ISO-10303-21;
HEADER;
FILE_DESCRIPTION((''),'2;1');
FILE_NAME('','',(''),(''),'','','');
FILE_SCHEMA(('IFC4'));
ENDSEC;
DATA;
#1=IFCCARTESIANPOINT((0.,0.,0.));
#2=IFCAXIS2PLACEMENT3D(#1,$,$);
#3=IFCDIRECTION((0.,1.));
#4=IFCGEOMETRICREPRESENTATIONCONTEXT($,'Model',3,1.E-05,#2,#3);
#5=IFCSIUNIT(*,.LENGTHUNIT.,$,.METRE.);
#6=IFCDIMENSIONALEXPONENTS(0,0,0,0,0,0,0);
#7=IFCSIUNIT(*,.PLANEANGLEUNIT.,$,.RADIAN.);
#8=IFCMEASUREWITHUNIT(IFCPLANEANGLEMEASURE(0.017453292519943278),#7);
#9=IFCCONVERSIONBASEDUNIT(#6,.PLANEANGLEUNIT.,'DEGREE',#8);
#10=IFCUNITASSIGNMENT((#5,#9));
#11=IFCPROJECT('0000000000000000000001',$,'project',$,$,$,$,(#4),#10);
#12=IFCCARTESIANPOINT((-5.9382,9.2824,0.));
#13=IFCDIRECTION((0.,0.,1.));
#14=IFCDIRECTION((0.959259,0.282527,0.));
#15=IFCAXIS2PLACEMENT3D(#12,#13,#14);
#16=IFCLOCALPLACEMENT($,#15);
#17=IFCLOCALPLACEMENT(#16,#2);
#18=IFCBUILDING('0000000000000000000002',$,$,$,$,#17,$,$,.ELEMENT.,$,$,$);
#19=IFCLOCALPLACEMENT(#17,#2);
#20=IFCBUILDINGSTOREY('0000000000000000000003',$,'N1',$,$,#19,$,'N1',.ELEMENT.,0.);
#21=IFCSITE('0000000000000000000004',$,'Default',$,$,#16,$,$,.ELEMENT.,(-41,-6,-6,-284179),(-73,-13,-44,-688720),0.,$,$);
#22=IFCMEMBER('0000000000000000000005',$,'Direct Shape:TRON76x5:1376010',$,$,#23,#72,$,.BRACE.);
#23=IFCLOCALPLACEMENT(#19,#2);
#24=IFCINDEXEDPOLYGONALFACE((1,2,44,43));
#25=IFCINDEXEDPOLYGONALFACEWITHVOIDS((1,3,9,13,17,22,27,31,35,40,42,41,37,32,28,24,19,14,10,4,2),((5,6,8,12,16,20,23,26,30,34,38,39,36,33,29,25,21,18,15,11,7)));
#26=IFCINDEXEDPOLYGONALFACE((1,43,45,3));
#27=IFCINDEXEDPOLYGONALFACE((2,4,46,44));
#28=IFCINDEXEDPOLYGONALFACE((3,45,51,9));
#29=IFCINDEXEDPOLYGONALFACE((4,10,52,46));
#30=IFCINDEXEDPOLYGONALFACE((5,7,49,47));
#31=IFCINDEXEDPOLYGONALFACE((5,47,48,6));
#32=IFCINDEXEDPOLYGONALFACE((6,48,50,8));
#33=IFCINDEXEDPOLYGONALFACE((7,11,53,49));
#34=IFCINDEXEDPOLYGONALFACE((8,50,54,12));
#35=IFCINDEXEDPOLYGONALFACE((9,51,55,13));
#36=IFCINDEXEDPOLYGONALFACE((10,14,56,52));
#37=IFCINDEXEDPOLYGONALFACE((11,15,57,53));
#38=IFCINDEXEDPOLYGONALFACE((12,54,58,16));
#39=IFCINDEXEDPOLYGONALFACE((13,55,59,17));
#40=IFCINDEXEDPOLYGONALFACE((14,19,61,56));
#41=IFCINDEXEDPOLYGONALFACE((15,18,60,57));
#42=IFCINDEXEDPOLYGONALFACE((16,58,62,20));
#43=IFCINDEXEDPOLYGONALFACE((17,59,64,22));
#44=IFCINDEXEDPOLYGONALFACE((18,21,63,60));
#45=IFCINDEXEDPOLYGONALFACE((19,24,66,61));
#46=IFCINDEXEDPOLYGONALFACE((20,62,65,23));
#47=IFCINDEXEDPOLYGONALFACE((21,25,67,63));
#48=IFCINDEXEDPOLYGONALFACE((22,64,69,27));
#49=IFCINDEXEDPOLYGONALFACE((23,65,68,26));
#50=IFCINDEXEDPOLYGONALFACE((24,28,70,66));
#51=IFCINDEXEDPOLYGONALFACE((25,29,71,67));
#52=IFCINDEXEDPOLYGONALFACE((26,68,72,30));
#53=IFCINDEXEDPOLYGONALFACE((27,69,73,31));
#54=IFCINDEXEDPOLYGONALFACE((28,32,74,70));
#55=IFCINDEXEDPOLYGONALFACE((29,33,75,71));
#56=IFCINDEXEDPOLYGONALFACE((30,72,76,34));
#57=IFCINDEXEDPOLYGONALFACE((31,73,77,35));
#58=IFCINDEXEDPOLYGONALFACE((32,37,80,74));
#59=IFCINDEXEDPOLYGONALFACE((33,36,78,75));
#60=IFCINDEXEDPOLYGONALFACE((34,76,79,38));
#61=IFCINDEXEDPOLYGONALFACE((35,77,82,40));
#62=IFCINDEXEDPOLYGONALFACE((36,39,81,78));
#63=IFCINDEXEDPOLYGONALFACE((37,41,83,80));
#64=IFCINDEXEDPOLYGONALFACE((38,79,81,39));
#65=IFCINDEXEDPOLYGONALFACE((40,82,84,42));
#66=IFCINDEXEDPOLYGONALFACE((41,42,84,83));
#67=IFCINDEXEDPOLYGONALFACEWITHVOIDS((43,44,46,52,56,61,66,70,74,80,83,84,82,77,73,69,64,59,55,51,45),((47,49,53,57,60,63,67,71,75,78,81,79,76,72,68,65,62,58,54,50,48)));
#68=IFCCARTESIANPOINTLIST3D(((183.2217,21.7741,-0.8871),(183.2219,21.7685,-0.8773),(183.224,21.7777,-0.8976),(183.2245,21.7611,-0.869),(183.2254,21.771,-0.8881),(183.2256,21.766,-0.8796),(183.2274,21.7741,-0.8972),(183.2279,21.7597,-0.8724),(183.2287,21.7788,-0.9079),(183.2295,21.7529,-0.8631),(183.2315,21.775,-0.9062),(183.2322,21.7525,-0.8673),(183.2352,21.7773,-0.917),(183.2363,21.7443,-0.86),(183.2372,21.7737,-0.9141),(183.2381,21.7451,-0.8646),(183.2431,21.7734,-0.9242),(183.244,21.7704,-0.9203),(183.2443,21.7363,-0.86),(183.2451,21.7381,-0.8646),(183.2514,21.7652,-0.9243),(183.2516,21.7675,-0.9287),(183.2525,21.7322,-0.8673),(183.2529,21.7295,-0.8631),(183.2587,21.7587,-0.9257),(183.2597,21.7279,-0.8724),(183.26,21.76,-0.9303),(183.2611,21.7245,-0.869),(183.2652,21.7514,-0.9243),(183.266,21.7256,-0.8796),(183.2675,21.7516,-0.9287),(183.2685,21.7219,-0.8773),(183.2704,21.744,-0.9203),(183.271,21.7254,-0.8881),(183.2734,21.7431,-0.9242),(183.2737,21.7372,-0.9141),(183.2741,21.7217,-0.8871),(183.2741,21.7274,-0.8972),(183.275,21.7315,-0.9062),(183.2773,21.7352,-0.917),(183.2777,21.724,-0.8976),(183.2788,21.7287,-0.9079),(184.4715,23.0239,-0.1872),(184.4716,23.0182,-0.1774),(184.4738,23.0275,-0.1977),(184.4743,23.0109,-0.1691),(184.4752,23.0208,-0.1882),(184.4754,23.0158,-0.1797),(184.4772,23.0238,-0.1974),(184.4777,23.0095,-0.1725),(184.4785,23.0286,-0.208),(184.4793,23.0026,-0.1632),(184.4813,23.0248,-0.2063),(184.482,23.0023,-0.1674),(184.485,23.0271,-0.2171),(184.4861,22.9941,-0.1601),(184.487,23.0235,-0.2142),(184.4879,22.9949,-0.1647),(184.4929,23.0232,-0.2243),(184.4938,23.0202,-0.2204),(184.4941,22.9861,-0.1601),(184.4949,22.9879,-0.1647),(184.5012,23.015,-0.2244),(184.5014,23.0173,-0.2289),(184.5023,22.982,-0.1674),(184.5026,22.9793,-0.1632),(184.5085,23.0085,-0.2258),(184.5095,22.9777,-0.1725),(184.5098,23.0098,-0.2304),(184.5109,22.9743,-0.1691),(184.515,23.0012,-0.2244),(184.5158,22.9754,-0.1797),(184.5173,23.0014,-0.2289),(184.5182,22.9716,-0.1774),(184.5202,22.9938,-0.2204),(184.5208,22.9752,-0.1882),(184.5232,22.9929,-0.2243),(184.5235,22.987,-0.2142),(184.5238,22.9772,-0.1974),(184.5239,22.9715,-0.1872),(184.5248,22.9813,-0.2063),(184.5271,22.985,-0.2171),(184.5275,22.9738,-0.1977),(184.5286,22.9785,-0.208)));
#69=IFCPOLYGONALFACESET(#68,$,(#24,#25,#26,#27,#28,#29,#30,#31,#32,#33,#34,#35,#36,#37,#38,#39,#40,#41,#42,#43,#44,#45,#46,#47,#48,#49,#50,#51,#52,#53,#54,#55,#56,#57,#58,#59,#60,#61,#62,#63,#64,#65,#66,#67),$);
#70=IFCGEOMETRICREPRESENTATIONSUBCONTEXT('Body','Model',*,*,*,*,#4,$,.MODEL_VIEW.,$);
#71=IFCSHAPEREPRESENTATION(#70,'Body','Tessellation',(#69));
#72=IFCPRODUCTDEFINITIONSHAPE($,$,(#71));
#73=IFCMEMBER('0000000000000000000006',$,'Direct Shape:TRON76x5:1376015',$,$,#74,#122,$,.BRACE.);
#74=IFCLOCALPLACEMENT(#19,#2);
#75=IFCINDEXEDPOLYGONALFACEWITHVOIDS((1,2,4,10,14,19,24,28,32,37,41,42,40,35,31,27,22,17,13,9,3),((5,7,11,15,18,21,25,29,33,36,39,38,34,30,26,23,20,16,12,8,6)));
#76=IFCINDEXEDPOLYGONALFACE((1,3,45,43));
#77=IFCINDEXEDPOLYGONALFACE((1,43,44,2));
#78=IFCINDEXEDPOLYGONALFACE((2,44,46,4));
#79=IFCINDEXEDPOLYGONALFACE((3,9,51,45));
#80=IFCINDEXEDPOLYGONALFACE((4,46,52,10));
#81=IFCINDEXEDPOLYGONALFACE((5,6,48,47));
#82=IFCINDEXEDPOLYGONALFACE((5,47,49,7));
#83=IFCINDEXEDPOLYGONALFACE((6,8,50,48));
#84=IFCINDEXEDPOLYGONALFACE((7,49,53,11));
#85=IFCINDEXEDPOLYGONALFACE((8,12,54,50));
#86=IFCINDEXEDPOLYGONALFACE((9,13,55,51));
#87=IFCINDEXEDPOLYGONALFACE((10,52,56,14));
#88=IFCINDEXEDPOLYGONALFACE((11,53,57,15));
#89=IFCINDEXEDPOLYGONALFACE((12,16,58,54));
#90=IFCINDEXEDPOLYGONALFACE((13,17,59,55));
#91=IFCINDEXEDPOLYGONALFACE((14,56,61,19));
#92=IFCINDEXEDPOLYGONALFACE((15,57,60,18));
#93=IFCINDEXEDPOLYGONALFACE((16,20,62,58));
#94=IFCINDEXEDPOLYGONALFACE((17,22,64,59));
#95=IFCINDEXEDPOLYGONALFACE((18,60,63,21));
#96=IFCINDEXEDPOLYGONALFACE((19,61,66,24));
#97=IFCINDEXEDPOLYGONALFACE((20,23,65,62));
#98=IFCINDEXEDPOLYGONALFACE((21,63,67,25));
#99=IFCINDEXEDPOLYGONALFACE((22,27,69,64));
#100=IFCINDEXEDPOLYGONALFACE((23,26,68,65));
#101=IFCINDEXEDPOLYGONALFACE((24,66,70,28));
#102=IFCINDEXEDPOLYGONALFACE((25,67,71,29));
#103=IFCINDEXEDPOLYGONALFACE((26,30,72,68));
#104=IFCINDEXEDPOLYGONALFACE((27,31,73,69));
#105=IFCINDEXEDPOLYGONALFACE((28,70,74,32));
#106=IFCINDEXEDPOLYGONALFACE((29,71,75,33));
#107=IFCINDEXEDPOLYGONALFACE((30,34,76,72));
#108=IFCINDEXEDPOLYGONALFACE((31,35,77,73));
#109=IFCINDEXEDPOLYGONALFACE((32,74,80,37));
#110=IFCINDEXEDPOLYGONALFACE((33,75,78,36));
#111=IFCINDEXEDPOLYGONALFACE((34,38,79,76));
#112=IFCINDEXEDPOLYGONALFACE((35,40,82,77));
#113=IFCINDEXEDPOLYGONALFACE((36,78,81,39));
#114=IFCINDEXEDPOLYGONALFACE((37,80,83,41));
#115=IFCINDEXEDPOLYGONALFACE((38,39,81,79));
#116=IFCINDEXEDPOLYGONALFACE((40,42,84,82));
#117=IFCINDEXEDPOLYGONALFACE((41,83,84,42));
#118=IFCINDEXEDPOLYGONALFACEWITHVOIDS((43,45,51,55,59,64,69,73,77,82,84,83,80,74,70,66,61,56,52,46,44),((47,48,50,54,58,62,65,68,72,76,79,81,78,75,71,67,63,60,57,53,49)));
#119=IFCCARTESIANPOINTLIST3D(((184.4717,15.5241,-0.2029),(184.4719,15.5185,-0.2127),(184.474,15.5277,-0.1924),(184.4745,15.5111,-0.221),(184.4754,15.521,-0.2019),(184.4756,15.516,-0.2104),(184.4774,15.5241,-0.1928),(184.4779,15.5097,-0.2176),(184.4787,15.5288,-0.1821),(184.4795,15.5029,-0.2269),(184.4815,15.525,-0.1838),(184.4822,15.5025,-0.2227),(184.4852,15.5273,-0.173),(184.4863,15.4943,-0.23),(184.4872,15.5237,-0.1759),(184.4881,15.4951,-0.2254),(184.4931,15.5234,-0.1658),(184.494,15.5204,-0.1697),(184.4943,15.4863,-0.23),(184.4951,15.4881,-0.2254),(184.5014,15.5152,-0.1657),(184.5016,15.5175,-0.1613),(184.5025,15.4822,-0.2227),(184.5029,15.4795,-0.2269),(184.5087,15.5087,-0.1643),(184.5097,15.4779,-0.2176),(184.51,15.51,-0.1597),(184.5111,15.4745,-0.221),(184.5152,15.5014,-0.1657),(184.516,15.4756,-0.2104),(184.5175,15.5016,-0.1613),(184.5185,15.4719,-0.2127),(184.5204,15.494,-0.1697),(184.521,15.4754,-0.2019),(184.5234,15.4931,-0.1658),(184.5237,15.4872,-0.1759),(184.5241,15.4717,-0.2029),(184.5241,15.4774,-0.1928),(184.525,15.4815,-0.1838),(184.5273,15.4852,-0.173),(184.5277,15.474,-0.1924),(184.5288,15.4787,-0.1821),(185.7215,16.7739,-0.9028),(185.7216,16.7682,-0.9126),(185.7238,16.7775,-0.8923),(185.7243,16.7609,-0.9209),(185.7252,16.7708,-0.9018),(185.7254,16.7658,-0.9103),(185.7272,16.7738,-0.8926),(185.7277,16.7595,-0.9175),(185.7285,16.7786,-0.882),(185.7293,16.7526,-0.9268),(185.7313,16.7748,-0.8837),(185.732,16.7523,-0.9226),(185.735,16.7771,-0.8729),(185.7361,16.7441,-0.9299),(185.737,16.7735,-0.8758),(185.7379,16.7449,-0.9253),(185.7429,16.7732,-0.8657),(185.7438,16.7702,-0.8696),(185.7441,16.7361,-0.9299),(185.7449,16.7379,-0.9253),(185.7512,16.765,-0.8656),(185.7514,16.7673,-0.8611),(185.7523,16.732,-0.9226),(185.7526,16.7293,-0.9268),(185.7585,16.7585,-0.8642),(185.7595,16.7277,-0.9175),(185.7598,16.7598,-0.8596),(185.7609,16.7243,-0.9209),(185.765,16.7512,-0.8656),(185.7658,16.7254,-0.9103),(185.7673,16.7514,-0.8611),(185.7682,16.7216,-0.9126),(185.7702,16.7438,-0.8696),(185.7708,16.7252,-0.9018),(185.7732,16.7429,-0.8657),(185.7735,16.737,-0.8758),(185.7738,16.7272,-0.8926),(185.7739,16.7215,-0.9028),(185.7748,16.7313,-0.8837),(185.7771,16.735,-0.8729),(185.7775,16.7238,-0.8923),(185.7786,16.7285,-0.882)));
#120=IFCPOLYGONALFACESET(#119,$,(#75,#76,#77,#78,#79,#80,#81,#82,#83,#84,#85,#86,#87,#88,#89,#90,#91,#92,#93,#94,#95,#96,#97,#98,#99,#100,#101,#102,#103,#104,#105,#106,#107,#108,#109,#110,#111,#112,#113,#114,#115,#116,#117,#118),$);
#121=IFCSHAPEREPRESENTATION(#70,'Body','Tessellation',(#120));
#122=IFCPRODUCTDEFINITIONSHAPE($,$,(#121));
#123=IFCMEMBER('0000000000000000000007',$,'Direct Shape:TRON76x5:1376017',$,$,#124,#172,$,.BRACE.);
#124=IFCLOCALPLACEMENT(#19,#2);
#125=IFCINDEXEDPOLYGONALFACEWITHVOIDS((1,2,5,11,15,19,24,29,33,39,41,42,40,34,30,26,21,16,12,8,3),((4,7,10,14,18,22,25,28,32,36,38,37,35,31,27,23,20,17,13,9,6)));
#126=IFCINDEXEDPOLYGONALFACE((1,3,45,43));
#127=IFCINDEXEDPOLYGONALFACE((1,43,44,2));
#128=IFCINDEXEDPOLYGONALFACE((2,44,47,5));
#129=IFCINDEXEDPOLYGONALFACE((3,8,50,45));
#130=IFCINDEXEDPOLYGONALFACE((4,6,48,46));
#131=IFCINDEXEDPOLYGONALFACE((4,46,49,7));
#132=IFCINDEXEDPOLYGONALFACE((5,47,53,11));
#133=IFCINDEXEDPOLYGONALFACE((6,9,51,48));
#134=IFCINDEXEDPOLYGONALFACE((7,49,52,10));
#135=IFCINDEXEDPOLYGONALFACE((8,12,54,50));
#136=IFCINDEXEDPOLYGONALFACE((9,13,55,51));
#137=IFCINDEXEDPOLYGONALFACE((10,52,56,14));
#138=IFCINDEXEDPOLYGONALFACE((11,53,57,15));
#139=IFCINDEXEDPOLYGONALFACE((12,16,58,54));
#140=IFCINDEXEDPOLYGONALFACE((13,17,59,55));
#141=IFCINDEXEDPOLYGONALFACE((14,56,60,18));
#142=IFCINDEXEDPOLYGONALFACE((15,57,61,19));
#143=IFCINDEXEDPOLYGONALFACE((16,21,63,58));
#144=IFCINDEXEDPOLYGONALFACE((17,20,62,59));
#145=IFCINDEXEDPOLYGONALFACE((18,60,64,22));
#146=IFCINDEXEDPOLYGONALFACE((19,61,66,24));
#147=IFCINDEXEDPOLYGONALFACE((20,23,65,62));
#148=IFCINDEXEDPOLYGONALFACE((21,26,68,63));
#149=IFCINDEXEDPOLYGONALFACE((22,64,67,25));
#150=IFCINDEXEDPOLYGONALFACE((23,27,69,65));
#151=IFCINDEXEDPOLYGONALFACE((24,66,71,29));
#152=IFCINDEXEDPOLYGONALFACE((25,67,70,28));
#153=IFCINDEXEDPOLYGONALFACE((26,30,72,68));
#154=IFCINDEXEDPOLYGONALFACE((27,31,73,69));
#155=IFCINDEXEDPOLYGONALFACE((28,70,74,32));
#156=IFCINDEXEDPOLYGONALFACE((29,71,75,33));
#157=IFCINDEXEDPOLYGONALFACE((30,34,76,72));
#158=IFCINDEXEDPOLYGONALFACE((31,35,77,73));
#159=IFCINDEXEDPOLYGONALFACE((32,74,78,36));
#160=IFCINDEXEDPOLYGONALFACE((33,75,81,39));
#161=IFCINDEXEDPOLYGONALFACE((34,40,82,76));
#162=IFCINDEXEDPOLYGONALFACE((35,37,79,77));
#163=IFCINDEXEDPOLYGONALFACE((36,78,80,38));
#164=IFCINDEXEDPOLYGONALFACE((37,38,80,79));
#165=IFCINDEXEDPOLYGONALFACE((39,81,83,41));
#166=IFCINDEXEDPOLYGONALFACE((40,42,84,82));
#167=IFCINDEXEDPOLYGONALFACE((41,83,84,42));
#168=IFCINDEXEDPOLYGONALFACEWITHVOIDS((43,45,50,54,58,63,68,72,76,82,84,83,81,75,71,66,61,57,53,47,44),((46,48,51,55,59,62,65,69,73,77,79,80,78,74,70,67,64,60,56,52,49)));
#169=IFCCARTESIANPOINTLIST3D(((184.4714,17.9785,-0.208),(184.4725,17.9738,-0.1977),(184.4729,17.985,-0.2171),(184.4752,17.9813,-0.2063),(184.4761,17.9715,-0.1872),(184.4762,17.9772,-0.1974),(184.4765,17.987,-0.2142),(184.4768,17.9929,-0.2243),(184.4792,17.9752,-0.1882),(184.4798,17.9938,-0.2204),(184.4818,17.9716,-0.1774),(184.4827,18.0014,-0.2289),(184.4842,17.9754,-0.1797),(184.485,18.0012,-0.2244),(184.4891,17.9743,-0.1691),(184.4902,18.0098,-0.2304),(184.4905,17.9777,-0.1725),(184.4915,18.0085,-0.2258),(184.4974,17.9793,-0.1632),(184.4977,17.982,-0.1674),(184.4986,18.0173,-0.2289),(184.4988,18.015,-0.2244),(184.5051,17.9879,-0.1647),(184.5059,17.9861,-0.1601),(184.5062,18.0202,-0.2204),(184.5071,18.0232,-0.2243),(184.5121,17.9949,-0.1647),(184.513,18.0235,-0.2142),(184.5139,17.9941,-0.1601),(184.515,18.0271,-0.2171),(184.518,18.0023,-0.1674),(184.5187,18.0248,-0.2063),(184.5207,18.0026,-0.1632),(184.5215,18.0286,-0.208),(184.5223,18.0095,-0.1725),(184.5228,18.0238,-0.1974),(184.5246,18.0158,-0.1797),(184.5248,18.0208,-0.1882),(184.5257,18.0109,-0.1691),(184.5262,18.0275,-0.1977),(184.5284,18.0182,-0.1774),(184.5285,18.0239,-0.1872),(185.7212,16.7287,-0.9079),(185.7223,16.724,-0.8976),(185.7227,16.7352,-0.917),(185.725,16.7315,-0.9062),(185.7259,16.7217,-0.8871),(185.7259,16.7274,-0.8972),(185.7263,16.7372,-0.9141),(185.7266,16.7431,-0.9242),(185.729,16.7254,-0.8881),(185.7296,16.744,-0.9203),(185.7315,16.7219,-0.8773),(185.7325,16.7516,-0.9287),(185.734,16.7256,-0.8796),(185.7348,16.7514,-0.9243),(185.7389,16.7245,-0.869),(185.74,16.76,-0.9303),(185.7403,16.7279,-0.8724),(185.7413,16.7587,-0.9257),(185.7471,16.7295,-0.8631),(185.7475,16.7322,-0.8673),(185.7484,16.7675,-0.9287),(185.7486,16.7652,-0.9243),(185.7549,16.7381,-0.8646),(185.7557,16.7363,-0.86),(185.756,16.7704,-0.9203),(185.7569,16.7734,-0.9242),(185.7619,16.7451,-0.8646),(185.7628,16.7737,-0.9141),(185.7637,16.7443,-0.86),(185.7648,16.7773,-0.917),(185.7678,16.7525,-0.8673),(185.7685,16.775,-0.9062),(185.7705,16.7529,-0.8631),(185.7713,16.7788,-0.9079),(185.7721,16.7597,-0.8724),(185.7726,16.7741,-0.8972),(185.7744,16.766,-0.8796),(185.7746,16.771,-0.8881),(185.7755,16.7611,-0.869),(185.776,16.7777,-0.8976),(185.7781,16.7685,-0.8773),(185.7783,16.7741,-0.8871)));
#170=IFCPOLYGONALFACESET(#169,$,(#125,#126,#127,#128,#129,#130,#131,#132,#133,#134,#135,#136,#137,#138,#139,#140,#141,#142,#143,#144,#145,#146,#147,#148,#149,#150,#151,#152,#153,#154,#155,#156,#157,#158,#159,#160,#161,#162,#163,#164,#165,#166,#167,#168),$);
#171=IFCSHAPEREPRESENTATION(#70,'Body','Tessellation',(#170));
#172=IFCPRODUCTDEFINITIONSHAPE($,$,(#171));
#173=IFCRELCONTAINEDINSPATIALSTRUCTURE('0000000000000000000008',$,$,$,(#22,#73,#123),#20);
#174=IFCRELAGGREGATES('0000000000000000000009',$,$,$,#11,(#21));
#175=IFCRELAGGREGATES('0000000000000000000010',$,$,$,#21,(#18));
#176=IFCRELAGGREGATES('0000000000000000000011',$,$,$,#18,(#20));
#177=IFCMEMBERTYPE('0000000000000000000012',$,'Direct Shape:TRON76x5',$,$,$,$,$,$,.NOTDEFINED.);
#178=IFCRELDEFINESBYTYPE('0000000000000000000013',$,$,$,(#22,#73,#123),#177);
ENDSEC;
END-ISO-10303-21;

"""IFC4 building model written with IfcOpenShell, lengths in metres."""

from ifc_helpers import new_model, entity, si_unit, converted_unit, direction, frame, frame_2d, origin, origin_2d_with_axis, place, context, subcontext, project, spatial, hollow_circle, extrude, type_object, element, save


model = new_model("IFC4")

# Units and contexts
model_context = context("Model", 3, precision=1e-05, world=origin(), true_north=direction((0.0, 1.0)))
body_context = subcontext(model_context, "Body", "Model", "MODEL_VIEW")
ifc_project = project(units=[si_unit("LENGTHUNIT", "METRE"), converted_unit("PLANEANGLEUNIT", "DEGREE", entity("IfcPlaneAngleMeasure", 0.017453292519943278), si_unit("PLANEANGLEUNIT", "RADIAN"), dimensions=[0, 0, 0, 0, 0, 0, 0])], contexts=[model_context])

# Site, building, storey
site_placement = place(None, frame((-5.9382, 9.2824, 0.0), z_axis=(0.0, 0.0, 1.0), x_axis=(0.959259, 0.282527, 0.0)))
site = spatial("IfcSite", under=ifc_project, at=site_placement, Name="Default", CompositionType="ELEMENT", RefLatitude=(-41, -6, -6, -284179), RefLongitude=(-73, -13, -44, -688720), RefElevation=0.0)
building_placement = place(site_placement, origin())
building = spatial("IfcBuilding", under=site, at=building_placement, CompositionType="ELEMENT")
storey_placement = place(building_placement, origin())
storey = spatial("IfcBuildingStorey", under=building, at=storey_placement, Name="N1", LongName="N1", CompositionType="ELEMENT", Elevation=0.0)

# Members
member_type_1 = type_object("IfcMemberType", Name="Direct Shape:TRON76x5", PredefinedType="NOTDEFINED")
member_1_placement = place(storey_placement, origin())
element("IfcMember", 1, at=member_1_placement, inside=storey, type_object=member_type_1, Name="Direct Shape:TRON76x5:1376010", PredefinedType="BRACE", context=body_context, shape_type="SweptSolid", body=[
    extrude(hollow_circle(Radius=0.0381, WallThickness=0.005, at=origin_2d_with_axis()), frame((183.2501, 21.7501, -0.8949), z_axis=(0.65744, 0.65744, 0.368166), x_axis=(0.260333, 0.260333, -0.92976)), (0.0, 0.0, 1.0), 1.901),
])
member_2_placement = place(storey_placement, origin())
element("IfcMember", 2, at=member_2_placement, inside=storey, type_object=member_type_1, Name="Direct Shape:TRON76x5:1376015", PredefinedType="BRACE", context=body_context, shape_type="SweptSolid", body=[
    extrude(hollow_circle(Radius=0.0381, WallThickness=0.005, at=frame_2d((0.0, 0.0), x_axis=(1.0, 0.0))), frame((184.5001, 15.5001, -0.1951), z_axis=(0.65744, 0.65744, -0.368166), x_axis=(0.260333, 0.260333, 0.92976)), (0.0, 0.0, 1.0), 1.901),
])
member_3_placement = place(storey_placement, origin())
element("IfcMember", 3, at=member_3_placement, inside=storey, type_object=member_type_1, Name="Direct Shape:TRON76x5:1376017", PredefinedType="BRACE", context=body_context, shape_type="SweptSolid", body=[
    extrude(hollow_circle(Radius=0.0381, WallThickness=0.005, at=origin_2d_with_axis()), frame((185.7499, 16.7501, -0.8949), z_axis=(-0.65744, 0.65744, 0.368166), x_axis=(-0.260333, 0.260333, -0.92976)), (0.0, 0.0, 1.0), 1.901),
])

save(model, "model.ifc")
